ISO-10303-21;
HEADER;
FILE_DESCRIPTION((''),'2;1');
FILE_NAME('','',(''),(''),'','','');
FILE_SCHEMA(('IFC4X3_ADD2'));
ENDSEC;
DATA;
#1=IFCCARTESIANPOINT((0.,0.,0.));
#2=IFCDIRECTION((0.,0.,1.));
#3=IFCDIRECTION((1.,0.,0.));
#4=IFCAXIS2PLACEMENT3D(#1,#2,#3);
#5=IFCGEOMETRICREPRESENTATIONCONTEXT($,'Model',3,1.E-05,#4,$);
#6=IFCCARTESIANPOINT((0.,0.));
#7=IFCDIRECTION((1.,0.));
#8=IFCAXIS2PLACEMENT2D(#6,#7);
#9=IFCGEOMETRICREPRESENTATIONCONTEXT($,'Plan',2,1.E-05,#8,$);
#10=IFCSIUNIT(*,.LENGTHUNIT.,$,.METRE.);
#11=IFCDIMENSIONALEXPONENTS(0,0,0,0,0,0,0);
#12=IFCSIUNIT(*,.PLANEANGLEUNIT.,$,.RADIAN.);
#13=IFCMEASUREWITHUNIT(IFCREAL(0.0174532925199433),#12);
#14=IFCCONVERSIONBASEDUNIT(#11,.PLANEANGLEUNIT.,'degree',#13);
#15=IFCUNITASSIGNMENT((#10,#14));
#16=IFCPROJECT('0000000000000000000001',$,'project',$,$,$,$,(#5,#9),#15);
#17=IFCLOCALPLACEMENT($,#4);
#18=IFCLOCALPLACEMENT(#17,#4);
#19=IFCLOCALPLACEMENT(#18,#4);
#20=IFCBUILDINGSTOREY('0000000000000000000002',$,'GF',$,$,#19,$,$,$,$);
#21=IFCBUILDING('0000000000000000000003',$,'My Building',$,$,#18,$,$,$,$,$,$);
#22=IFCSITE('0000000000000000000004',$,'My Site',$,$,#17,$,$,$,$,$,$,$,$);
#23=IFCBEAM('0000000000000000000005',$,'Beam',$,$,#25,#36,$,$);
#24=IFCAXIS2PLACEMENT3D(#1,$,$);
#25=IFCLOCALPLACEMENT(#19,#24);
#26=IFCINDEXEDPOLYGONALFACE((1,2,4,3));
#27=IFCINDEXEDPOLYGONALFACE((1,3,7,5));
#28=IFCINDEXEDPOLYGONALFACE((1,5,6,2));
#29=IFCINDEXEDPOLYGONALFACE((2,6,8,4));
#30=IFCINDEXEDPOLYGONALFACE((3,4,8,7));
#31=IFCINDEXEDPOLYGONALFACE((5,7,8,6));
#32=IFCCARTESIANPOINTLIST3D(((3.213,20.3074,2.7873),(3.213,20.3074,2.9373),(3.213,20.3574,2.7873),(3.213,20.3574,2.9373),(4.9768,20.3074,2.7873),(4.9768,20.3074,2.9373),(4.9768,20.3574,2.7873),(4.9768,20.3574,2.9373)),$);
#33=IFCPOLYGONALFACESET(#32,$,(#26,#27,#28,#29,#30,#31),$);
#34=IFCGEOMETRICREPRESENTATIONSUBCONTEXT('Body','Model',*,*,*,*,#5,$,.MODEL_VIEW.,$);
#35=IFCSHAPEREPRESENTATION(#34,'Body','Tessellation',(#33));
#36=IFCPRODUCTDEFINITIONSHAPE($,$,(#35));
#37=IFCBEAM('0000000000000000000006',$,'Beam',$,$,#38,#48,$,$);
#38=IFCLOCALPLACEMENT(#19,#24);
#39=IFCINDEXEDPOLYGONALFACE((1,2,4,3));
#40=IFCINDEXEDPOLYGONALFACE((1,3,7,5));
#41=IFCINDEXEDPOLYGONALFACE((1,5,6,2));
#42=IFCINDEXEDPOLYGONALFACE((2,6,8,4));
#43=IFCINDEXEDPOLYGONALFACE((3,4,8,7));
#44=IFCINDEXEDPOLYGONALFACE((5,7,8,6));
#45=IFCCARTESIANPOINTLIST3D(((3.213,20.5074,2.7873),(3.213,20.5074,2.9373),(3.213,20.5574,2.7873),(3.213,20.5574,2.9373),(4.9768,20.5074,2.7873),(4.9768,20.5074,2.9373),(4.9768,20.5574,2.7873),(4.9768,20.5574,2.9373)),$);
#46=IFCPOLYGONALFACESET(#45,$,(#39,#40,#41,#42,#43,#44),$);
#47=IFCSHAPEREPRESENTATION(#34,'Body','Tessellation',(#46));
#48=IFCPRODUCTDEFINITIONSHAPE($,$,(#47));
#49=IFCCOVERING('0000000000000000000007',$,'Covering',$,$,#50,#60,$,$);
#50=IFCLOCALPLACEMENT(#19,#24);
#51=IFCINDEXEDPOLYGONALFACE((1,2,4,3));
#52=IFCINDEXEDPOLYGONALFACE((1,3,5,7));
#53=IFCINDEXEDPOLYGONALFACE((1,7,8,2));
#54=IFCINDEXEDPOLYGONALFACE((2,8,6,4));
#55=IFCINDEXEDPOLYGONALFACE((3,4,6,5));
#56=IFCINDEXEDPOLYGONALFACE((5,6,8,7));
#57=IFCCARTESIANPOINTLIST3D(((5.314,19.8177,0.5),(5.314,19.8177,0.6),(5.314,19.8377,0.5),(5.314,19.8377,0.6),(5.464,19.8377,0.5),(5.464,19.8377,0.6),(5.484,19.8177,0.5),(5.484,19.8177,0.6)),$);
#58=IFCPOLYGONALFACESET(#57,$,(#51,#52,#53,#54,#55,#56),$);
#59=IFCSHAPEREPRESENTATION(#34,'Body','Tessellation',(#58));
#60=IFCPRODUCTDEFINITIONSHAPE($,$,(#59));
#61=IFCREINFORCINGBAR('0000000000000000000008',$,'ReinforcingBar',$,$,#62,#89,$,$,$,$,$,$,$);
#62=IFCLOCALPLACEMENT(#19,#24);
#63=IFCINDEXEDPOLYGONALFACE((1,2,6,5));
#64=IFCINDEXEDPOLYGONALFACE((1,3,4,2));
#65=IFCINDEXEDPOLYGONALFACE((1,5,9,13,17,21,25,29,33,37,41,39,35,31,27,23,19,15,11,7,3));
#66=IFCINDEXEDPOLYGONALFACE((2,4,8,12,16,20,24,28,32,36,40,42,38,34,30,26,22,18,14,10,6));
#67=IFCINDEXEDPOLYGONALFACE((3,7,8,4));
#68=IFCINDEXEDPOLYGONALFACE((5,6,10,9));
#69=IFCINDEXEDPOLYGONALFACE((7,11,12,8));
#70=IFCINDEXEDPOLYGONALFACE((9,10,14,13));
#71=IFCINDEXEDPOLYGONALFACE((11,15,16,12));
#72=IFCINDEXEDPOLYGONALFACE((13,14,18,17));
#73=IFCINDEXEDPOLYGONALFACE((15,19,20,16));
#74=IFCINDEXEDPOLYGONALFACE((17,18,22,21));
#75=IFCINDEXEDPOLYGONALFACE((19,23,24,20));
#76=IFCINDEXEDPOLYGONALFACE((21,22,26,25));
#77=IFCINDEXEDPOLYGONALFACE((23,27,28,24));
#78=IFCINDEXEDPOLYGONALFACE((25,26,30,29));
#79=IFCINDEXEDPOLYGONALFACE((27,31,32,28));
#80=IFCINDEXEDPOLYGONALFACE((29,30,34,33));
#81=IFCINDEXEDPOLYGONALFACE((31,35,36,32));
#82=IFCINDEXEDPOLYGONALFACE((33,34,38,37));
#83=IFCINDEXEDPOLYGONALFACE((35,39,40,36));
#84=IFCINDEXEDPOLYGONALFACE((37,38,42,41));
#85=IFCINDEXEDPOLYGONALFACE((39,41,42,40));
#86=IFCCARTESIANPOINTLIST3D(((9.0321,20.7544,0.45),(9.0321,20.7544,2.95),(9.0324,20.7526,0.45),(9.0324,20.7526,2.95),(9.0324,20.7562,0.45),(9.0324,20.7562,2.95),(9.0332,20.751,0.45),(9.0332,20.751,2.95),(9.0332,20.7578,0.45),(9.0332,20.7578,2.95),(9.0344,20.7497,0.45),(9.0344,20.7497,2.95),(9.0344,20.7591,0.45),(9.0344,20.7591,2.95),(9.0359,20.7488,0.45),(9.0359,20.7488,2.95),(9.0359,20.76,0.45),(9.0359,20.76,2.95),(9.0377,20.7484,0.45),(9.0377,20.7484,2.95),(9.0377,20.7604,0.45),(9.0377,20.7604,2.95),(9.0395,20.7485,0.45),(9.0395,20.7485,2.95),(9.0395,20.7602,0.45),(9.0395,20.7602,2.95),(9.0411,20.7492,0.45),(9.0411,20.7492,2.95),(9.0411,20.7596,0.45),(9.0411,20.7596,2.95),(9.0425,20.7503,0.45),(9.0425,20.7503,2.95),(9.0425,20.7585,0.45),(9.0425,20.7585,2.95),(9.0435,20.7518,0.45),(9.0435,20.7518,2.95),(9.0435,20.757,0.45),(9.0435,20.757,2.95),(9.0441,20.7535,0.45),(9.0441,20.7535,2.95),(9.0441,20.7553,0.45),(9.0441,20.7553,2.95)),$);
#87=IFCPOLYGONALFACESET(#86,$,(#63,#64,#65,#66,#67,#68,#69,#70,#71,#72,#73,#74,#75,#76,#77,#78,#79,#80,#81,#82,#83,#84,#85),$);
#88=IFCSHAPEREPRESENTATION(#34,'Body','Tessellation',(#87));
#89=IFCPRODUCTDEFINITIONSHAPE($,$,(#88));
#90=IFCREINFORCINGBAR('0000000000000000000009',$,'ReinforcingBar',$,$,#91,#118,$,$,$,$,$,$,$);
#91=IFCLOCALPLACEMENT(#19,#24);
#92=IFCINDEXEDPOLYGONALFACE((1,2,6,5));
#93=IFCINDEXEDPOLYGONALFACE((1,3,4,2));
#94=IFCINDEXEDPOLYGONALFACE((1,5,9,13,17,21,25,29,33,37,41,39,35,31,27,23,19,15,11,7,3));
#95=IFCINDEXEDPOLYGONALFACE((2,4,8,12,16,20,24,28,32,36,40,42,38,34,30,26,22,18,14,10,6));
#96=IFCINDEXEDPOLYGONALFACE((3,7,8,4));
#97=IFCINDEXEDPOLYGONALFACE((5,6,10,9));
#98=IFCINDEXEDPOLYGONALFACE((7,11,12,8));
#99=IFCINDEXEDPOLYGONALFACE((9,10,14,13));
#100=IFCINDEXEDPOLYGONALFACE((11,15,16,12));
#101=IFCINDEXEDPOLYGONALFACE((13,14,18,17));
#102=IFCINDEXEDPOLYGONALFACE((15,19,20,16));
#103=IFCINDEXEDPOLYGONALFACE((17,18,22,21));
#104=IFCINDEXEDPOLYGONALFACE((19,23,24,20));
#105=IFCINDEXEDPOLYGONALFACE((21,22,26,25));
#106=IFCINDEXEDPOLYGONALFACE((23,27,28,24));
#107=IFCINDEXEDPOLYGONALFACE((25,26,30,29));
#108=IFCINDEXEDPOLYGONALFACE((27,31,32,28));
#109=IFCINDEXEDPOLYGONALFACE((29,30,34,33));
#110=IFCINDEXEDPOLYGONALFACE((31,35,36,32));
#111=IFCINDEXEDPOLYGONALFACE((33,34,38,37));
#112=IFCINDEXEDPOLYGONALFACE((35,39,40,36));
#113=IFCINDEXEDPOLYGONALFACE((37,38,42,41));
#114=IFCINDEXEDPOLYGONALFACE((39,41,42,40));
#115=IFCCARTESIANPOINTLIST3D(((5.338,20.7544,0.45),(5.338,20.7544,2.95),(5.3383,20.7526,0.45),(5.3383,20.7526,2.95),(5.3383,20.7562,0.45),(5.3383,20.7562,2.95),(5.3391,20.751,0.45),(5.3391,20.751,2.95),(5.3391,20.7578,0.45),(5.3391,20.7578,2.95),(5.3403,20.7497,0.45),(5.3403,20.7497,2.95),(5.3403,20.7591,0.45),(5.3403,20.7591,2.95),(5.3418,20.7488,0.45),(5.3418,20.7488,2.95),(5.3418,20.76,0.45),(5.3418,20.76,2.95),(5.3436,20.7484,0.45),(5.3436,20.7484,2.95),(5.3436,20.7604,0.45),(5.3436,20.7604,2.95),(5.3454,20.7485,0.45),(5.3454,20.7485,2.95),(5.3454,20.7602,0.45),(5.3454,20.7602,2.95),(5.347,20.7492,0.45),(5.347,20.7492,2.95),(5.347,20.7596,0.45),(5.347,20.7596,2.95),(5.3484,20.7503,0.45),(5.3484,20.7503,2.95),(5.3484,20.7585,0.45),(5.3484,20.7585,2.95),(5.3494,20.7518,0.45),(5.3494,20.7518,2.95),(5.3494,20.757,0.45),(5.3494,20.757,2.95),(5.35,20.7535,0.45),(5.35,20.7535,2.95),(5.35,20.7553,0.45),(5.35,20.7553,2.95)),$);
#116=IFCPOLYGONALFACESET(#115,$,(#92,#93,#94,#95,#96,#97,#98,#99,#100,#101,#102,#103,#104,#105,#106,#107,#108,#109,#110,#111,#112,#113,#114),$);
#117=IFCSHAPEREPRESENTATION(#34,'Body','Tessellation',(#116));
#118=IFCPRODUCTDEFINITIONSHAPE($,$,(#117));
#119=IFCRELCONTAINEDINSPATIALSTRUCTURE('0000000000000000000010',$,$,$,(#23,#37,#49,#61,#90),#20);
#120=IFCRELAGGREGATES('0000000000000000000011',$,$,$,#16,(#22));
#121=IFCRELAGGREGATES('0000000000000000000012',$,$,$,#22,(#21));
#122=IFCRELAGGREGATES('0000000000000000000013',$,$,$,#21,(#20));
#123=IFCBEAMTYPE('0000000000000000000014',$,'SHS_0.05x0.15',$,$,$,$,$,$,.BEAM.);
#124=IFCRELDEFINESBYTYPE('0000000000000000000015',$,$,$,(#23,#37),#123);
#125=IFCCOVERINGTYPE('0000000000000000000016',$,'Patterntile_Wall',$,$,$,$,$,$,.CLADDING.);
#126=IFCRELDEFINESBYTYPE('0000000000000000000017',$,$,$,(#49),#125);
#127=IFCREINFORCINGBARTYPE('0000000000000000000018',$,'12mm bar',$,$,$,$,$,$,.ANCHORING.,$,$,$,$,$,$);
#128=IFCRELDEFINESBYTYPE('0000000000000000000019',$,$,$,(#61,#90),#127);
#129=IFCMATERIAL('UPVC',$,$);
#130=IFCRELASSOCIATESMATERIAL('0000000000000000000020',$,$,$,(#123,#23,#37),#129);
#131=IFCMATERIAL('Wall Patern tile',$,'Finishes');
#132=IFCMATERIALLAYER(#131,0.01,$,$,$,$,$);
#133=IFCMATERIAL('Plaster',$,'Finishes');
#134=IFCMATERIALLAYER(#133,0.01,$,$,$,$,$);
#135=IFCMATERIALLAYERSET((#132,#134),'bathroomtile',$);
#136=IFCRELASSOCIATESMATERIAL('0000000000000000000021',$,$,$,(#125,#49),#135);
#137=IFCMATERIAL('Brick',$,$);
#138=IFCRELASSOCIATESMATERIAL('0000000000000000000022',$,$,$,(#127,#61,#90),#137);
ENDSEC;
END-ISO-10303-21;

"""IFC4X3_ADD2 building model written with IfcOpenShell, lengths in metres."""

from ifc_helpers import new_model, entity, si_unit, converted_unit, frame, origin_with_axes, origin_2d_with_axis, place, context, subcontext, project, spatial, line, indexed_curve, rectangle, circle, outline, extrude, material, layer, layer_set, layer_usage, material_profile, profile_set, profile_usage, type_object, element, save


model = new_model("IFC4X3_ADD2")

# Units and contexts
model_context = context("Model", 3, precision=1e-05, world=origin_with_axes())
plan_context = context("Plan", 2, precision=1e-05, world=origin_2d_with_axis())
body_context_1 = subcontext(model_context, "Body", "Model", "MODEL_VIEW")
ifc_project = project(units=[si_unit("LENGTHUNIT", "METRE"), converted_unit("PLANEANGLEUNIT", "degree", entity("IfcReal", 0.0174532925199433), si_unit("PLANEANGLEUNIT", "RADIAN"), dimensions=[0, 0, 0, 0, 0, 0, 0])], contexts=[model_context, plan_context])

# Site, building, storey
site_placement = place(None, origin_with_axes())
site = spatial("IfcSite", under=ifc_project, at=site_placement, Name="My Site")
building_placement = place(site_placement, origin_with_axes())
building = spatial("IfcBuilding", under=site, at=building_placement, Name="My Building")
storey_placement = place(building_placement, origin_with_axes())
storey = spatial("IfcBuildingStorey", under=building, at=storey_placement, Name="GF")

# Shared definitions
ifc_material_1 = material(Name="Brick")

# Beams
ifc_material_2 = material(Name="UPVC")
ifc_material_profile_1 = material_profile(ifc_material_2, rectangle(XDim=0.05, YDim=0.15))
ifc_profile_set_1 = profile_set([ifc_material_profile_1])
beam_type = type_object("IfcBeamType", Name="SHS_0.05x0.15", PredefinedType="BEAM", material=ifc_profile_set_1)
ifc_profile_usage_1 = profile_usage(ifc_profile_set_1)
beam_1_placement = place(storey_placement, frame((3.213, 20.3324, 2.8623), z_axis=(1.0, 0.0, 0.0), x_axis=(0.0, 1.0, 0.0)))
element("IfcBeam", 1, at=beam_1_placement, inside=storey, type_object=beam_type, material=ifc_profile_usage_1, Name="Beam", context=body_context_1, shape_type="SweptSolid", body=[
    extrude(rectangle(XDim=0.05, YDim=0.15), origin_with_axes(), (0.0, 0.0, 1.0), 1.7638),
])
ifc_profile_usage_2 = profile_usage(ifc_profile_set_1)
beam_2_placement = place(storey_placement, frame((3.213, 20.5324, 2.8623), z_axis=(1.0, 0.0, 0.0), x_axis=(0.0, 1.0, 0.0)))
element("IfcBeam", 2, at=beam_2_placement, inside=storey, type_object=beam_type, material=ifc_profile_usage_2, Name="Beam", context=body_context_1, shape_type="SweptSolid", body=[
    extrude(rectangle(XDim=0.05, YDim=0.15), origin_with_axes(), (0.0, 0.0, 1.0), 1.7638),
])

# Covering
ifc_material_3 = material(Name="Wall Patern tile", Category="Finishes")
ifc_layer_1 = layer(ifc_material_3, 0.01)
ifc_material_4 = material(Name="Plaster", Category="Finishes")
ifc_layer_2 = layer(ifc_material_4, 0.01)
ifc_layer_set_1 = layer_set([ifc_layer_1, ifc_layer_2], Name="bathroomtile")
ifc_layer_usage_1 = layer_usage(ifc_layer_set_1, "AXIS2", "NEGATIVE", 0.0)
covering_type_1 = type_object("IfcCoveringType", Name="Patterntile_Wall", PredefinedType="CLADDING", material=ifc_layer_set_1)
covering_1_placement = place(storey_placement, frame((5.484, 19.8177, 0.5), z_axis=(0.0, 0.0, 1.0), x_axis=(-1.0, 0.0, 0.0)))
element("IfcCovering", 3, at=covering_1_placement, inside=storey, type_object=covering_type_1, material=ifc_layer_usage_1, Name="Covering", context=body_context_1, shape_type="SweptSolid", body=[
    extrude(outline(indexed_curve([(0.02, -0.02), (0.0, 0.0), (0.17, 0.0), (0.17, -0.02)], segments=[line(1, 2, 3, 4, 1)])), origin_with_axes(), (0.0, 0.0, 1.0), 0.1),
])

# Reinforcing bars
ifc_material_profile_2 = material_profile(ifc_material_1, circle(Radius=0.006))
ifc_profile_set_2 = profile_set([ifc_material_profile_2])
ifc_profile_usage_3 = profile_usage(ifc_profile_set_2, cardinal=5)
reinforcing_bar_type = type_object("IfcReinforcingBarType", Name="12mm bar", PredefinedType="ANCHORING", material=ifc_profile_set_2)
reinforcing_bar_1_placement = place(storey_placement, frame((9.0381, 20.7544, 0.45), z_axis=(0.0, 0.0, 1.0), x_axis=(-1.0, 0.0, 0.0)))
element("IfcReinforcingBar", 4, at=reinforcing_bar_1_placement, inside=storey, type_object=reinforcing_bar_type, material=ifc_profile_usage_3, Name="ReinforcingBar", context=body_context_1, shape_type="SweptSolid", body=[
    extrude(circle(Radius=0.006), origin_with_axes(), (0.0, 0.0, 1.0), 2.5),
])
ifc_profile_usage_4 = profile_usage(ifc_profile_set_2, cardinal=5)
reinforcing_bar_2_placement = place(storey_placement, frame((5.344, 20.7544, 0.45), z_axis=(0.0, 0.0, 1.0), x_axis=(-1.0, 0.0, 0.0)))
element("IfcReinforcingBar", 5, at=reinforcing_bar_2_placement, inside=storey, type_object=reinforcing_bar_type, material=ifc_profile_usage_4, Name="ReinforcingBar", context=body_context_1, shape_type="SweptSolid", body=[
    extrude(circle(Radius=0.006), origin_with_axes(), (0.0, 0.0, 1.0), 2.5),
])

save(model, "model.ifc")
